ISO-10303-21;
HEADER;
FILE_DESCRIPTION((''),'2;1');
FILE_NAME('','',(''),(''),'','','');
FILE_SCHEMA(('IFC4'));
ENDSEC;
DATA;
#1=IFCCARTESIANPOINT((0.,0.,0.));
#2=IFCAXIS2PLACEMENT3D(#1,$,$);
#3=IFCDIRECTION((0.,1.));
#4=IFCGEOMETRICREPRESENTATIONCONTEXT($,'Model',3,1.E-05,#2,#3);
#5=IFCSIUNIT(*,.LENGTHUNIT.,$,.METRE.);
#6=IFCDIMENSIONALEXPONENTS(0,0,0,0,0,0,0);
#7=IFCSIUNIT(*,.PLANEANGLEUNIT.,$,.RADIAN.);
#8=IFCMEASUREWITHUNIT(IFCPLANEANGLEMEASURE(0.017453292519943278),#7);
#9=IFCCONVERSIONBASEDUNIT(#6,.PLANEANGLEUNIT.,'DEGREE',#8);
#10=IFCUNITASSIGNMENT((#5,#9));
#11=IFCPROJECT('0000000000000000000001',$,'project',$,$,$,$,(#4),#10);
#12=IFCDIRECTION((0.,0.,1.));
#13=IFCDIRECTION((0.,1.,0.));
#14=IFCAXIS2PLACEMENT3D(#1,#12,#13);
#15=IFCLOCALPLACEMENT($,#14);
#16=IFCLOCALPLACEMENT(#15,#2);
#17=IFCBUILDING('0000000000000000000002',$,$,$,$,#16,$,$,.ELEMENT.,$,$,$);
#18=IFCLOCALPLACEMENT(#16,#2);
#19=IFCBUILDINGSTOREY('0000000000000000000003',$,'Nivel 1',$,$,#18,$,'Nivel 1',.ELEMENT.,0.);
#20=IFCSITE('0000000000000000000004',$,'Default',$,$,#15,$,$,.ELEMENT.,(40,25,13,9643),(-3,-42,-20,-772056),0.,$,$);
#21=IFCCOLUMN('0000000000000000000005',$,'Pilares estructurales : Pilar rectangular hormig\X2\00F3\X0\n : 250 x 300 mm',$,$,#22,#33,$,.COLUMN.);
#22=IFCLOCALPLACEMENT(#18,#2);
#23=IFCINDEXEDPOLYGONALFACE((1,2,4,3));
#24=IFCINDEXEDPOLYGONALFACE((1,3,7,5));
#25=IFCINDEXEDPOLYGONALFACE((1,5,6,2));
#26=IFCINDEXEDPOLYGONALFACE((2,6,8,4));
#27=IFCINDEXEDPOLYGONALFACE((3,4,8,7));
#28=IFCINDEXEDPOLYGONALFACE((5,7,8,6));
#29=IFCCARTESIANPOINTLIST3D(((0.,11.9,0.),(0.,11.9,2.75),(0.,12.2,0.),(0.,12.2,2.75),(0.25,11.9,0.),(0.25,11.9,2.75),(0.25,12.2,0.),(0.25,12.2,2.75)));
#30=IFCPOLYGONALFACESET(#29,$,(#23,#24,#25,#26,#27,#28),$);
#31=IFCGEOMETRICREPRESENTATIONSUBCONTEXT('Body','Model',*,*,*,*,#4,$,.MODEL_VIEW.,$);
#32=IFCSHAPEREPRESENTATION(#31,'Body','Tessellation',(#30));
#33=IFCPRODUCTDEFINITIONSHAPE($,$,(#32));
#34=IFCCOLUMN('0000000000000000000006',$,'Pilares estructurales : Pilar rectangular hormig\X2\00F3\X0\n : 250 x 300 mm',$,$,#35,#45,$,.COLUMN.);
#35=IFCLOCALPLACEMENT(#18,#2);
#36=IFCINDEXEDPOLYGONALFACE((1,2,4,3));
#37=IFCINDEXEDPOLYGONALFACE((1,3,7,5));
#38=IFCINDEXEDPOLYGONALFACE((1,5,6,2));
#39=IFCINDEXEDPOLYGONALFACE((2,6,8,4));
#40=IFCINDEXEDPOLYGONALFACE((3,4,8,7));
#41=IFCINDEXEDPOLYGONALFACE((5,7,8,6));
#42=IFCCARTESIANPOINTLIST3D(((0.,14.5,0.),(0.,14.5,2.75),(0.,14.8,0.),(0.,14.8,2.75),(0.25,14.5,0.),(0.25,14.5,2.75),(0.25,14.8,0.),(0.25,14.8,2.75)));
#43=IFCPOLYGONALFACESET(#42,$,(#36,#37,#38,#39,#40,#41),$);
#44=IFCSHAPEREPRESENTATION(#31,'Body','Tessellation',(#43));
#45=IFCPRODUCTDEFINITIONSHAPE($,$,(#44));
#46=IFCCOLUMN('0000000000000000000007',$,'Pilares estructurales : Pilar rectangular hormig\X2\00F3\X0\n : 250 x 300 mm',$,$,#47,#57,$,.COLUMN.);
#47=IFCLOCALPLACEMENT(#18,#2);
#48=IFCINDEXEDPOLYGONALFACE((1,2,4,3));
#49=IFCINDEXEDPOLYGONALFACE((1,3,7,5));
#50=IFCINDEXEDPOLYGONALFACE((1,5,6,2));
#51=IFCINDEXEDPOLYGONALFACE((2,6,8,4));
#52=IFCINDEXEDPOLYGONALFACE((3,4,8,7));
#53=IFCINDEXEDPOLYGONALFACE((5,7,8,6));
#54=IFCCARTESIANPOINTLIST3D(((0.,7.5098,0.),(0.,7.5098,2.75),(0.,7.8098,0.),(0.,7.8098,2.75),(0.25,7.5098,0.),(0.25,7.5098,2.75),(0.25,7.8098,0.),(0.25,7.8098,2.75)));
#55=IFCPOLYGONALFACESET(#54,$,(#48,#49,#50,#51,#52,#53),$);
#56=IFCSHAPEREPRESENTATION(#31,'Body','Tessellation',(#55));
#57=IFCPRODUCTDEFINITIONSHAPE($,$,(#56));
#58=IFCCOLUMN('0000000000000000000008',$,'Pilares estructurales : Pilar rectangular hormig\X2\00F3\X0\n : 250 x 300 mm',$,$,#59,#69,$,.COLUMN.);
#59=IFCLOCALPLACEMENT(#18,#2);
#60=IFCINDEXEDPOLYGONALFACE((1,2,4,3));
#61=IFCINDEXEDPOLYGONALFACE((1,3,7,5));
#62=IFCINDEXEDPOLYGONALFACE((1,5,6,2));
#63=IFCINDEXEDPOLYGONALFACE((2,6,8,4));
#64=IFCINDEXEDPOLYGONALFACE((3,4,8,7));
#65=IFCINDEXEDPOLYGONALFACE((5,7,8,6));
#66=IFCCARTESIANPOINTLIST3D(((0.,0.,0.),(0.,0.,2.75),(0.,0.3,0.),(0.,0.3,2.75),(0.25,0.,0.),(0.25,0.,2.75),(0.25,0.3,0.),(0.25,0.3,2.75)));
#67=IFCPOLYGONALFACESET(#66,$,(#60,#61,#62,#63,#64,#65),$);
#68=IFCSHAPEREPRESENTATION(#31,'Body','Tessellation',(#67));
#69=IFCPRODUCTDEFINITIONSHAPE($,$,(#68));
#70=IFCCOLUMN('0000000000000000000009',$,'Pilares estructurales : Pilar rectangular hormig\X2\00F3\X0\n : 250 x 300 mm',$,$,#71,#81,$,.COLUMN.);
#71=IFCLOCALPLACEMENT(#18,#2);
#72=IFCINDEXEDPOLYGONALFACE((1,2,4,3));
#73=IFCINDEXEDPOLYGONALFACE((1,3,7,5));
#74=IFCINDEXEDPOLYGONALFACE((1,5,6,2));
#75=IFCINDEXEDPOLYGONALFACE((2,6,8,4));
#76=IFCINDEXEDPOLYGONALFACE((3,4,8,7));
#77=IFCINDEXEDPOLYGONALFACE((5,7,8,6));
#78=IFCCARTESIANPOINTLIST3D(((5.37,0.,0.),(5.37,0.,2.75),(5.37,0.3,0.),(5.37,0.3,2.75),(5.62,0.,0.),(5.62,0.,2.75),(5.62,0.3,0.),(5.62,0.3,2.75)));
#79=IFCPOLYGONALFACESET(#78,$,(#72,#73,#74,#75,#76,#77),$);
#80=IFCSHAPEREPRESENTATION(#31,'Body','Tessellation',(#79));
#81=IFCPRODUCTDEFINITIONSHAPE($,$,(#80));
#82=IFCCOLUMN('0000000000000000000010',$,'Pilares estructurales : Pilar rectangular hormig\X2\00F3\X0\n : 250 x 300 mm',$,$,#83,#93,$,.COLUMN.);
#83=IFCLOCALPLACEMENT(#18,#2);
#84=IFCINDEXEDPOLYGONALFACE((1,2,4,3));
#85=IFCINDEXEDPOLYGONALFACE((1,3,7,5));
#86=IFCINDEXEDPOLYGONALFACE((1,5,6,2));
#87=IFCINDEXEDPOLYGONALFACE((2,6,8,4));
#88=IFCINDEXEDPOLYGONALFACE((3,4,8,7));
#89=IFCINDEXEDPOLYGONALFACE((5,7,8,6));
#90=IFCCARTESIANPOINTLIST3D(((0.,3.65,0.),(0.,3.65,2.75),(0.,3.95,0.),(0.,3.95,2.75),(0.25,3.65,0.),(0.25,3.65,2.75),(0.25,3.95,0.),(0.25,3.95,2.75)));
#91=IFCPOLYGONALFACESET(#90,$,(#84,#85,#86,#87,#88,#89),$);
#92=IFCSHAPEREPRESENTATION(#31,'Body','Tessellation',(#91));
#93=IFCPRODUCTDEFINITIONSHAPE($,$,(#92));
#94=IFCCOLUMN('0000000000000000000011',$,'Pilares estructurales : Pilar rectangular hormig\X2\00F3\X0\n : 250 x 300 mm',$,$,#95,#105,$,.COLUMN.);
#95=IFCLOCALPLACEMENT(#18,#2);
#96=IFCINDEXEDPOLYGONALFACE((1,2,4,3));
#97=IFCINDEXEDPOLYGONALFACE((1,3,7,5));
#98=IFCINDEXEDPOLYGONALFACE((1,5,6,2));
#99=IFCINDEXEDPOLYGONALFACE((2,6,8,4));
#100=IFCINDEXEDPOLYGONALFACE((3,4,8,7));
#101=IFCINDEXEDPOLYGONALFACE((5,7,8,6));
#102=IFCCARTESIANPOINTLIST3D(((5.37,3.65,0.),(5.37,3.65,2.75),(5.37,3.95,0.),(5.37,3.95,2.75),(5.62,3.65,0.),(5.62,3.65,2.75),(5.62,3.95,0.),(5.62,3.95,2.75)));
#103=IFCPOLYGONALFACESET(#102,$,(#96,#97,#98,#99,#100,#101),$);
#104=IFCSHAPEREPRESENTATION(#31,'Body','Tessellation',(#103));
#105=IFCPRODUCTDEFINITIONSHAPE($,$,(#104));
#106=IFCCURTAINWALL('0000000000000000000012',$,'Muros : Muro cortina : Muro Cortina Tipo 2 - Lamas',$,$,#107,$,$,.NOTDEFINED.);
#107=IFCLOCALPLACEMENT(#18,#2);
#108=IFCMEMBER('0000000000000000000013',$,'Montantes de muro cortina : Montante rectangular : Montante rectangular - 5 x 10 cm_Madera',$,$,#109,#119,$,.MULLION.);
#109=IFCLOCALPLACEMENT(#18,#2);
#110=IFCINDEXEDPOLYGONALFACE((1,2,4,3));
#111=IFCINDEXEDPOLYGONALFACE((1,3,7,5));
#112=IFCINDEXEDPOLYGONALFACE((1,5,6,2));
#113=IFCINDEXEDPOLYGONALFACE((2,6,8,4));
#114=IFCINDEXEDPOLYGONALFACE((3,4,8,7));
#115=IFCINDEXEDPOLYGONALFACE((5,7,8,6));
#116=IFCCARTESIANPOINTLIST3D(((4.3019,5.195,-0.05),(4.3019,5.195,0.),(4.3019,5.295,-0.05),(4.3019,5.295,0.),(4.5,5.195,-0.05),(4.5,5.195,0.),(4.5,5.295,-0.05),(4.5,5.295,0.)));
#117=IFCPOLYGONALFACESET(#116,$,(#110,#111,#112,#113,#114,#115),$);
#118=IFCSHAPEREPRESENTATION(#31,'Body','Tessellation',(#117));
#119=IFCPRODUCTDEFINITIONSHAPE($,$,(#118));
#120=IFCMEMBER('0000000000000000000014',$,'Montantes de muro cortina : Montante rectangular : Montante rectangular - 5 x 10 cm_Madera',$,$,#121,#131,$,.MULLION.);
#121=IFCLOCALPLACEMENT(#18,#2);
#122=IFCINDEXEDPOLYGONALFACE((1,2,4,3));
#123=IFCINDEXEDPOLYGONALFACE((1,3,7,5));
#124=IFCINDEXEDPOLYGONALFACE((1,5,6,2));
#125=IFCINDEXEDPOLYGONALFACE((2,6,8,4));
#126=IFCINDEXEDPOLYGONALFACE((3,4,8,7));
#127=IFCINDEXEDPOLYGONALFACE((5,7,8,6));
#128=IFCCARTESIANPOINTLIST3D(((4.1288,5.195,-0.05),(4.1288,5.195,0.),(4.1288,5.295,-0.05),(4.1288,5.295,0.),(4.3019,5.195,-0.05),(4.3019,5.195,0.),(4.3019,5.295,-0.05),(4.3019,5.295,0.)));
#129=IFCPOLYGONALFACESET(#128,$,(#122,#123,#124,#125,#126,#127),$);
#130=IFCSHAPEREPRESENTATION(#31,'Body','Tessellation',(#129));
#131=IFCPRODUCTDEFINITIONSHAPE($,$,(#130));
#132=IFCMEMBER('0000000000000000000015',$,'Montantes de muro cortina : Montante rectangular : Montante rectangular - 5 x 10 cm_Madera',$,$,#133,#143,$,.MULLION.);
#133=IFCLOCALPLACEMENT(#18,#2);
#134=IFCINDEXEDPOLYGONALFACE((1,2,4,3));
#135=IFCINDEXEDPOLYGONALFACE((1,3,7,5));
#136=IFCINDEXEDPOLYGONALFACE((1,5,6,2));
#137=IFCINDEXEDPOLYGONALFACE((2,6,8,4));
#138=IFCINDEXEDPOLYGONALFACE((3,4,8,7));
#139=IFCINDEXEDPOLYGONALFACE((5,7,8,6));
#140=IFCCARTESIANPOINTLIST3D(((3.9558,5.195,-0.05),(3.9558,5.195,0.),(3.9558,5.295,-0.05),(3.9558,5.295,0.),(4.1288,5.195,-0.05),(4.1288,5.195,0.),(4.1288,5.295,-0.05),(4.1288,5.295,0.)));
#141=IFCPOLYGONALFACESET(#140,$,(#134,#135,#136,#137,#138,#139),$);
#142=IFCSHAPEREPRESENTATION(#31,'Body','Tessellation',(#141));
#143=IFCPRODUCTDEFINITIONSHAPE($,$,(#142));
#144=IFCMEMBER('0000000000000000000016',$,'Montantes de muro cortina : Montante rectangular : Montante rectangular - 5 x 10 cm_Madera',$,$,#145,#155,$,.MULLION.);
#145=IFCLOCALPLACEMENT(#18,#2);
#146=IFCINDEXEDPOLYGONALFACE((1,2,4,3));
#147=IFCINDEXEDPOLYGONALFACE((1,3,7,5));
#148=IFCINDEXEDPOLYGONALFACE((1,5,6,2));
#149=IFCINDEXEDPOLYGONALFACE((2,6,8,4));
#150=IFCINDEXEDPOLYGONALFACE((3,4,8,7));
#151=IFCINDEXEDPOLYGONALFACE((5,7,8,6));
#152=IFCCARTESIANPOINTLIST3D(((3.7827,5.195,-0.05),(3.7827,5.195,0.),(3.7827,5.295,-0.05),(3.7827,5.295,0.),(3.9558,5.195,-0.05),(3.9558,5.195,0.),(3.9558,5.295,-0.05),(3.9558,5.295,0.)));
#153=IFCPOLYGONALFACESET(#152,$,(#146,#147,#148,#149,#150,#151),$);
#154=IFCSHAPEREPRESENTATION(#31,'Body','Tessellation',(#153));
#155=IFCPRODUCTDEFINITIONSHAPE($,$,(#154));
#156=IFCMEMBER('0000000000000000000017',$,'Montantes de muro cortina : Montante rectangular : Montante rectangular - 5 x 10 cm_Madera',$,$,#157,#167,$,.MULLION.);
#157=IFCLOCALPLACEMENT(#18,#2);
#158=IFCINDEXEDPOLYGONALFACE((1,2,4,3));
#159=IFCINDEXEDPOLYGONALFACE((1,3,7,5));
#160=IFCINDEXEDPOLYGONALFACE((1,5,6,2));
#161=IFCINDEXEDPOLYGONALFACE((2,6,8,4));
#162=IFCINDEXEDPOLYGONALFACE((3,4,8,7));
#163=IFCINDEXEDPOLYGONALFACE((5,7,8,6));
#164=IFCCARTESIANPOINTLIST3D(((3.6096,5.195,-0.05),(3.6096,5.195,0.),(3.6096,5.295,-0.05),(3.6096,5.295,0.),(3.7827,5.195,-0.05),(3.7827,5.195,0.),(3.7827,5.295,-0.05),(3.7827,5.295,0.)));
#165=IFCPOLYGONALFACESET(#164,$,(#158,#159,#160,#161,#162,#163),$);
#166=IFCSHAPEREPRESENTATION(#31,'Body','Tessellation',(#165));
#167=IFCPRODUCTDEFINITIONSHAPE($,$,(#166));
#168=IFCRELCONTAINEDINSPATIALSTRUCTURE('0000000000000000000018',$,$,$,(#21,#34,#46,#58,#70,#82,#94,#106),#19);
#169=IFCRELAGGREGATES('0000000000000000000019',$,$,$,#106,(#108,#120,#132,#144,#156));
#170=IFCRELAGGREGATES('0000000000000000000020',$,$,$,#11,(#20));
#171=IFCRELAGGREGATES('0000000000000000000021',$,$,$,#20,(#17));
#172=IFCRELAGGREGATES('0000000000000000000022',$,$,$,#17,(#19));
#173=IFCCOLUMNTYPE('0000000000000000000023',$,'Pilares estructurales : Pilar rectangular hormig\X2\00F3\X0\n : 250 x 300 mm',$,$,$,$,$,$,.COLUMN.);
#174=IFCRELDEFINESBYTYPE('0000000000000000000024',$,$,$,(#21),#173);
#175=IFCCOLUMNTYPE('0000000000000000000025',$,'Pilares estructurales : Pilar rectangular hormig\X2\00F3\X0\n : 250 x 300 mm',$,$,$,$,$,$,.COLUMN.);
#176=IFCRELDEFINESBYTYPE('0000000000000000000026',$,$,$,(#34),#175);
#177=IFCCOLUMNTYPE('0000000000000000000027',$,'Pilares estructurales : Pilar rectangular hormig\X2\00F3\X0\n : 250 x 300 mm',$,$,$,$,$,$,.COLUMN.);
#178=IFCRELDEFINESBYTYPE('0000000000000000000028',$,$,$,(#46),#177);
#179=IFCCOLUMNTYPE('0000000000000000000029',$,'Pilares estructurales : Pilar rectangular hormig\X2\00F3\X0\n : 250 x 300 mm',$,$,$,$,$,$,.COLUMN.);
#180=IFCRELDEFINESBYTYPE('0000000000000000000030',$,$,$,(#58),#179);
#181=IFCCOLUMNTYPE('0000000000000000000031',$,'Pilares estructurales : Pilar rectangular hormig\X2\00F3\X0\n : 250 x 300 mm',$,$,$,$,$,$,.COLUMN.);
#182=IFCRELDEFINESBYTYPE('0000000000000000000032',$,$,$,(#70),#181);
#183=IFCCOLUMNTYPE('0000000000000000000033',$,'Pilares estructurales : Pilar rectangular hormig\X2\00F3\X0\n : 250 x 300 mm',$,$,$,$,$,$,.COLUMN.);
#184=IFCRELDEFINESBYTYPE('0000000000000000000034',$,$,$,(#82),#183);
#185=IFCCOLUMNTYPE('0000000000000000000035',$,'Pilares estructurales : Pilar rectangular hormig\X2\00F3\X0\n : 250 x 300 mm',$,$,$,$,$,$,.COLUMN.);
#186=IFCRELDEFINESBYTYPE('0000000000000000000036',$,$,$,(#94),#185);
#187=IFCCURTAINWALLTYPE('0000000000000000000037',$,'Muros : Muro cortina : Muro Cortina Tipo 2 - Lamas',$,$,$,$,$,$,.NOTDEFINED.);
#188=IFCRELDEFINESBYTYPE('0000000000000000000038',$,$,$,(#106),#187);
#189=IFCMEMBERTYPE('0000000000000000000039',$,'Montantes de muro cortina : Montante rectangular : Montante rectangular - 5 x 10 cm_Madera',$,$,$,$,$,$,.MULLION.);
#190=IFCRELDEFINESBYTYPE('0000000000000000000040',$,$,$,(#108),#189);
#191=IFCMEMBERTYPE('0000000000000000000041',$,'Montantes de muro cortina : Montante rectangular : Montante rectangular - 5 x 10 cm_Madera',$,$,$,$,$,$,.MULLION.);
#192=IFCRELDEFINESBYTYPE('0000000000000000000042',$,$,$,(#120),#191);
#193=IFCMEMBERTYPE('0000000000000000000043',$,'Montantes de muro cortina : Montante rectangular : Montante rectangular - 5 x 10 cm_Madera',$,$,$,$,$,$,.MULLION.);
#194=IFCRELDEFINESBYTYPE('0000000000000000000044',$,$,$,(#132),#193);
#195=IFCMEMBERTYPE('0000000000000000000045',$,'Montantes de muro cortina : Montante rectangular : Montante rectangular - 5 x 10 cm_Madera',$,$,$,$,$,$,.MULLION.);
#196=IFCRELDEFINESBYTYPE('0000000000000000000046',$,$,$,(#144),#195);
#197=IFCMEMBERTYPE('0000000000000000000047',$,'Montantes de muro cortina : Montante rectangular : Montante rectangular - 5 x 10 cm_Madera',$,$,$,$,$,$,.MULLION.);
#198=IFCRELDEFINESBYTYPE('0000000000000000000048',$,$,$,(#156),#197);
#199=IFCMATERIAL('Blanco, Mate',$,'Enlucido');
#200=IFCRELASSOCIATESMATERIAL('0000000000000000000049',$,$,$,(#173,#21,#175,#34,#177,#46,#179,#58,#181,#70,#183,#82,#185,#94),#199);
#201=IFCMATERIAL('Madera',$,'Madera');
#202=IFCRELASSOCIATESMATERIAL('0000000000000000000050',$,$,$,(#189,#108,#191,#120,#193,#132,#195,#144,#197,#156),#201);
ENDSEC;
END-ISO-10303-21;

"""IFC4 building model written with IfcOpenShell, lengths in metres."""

from ifc_helpers import new_model, entity, si_unit, converted_unit, direction, frame, origin, place, context, subcontext, project, spatial, indexed_curve, outline, extrude, source, transform, mapped, material, type_object, type_shapes, element, aggregate, save


model = new_model("IFC4")

# Units and contexts
model_context = context("Model", 3, precision=1e-05, world=origin(), true_north=direction((0.0, 1.0)))
body_context = subcontext(model_context, "Body", "Model", "MODEL_VIEW")
ifc_project = project(units=[si_unit("LENGTHUNIT", "METRE"), converted_unit("PLANEANGLEUNIT", "DEGREE", entity("IfcPlaneAngleMeasure", 0.017453292519943278), si_unit("PLANEANGLEUNIT", "RADIAN"), dimensions=[0, 0, 0, 0, 0, 0, 0])], contexts=[model_context])

# Site, building, storey
site_placement = place(None, frame((0.0, 0.0, 0.0), z_axis=(0.0, 0.0, 1.0), x_axis=(0.0, 1.0, 0.0)))
site = spatial("IfcSite", under=ifc_project, at=site_placement, Name="Default", CompositionType="ELEMENT", RefLatitude=(40, 25, 13, 9643), RefLongitude=(-3, -42, -20, -772056), RefElevation=0.0)
building_placement = place(site_placement, origin())
building = spatial("IfcBuilding", under=site, at=building_placement, CompositionType="ELEMENT")
storey_placement = place(building_placement, origin())
storey = spatial("IfcBuildingStorey", under=building, at=storey_placement, Name="Nivel 1", LongName="Nivel 1", CompositionType="ELEMENT", Elevation=0.0)

# Columns
ifc_material_1 = material(Name="Blanco, Mate", Category="Enlucido")
column_type_1 = type_object("IfcColumnType", Name="Pilares estructurales : Pilar rectangular hormigón : 250 x 300 mm", PredefinedType="COLUMN", material=ifc_material_1)
shared_shape_1 = source(origin(), body_context, "Body", "SweptSolid", [
    extrude(outline(indexed_curve([(-1.375, -0.15), (1.375, -0.15), (1.375, 0.15), (-1.375, 0.15), (-1.375, -0.15)], self_intersect=False)), frame((0.0, 12.05, 1.375), z_axis=(1.0, 0.0, 0.0), x_axis=(0.0, 0.0, 1.0)), (0.0, 0.0, 1.0), 0.25),
])
type_shapes(column_type_1, [shared_shape_1])
column_1_placement = place(storey_placement, origin())
element("IfcColumn", 1, at=column_1_placement, inside=storey, type_object=column_type_1, material=ifc_material_1, Name="Pilares estructurales : Pilar rectangular hormigón : 250 x 300 mm", PredefinedType="COLUMN", context=body_context, shape_type="MappedRepresentation", body=[
    mapped(shared_shape_1, transform((0.0, 0.0, 0.0), scale=1.0)),
])
column_type_2 = type_object("IfcColumnType", Name="Pilares estructurales : Pilar rectangular hormigón : 250 x 300 mm", PredefinedType="COLUMN", material=ifc_material_1)
shared_shape_2 = source(origin(), body_context, "Body", "SweptSolid", [
    extrude(outline(indexed_curve([(-1.375, -0.15), (1.375, -0.15), (1.375, 0.15), (-1.375, 0.15), (-1.375, -0.15)], self_intersect=False)), frame((0.0, 14.65, 1.375), z_axis=(1.0, 0.0, 0.0), x_axis=(0.0, 0.0, 1.0)), (0.0, 0.0, 1.0), 0.25),
])
type_shapes(column_type_2, [shared_shape_2])
column_2_placement = place(storey_placement, origin())
element("IfcColumn", 2, at=column_2_placement, inside=storey, type_object=column_type_2, material=ifc_material_1, Name="Pilares estructurales : Pilar rectangular hormigón : 250 x 300 mm", PredefinedType="COLUMN", context=body_context, shape_type="MappedRepresentation", body=[
    mapped(shared_shape_2, transform((0.0, 0.0, 0.0), scale=1.0)),
])
column_type_3 = type_object("IfcColumnType", Name="Pilares estructurales : Pilar rectangular hormigón : 250 x 300 mm", PredefinedType="COLUMN", material=ifc_material_1)
shared_shape_3 = source(origin(), body_context, "Body", "SweptSolid", [
    extrude(outline(indexed_curve([(-1.375, -0.15), (1.375, -0.15), (1.375, 0.15), (-1.375, 0.15), (-1.375, -0.15)], self_intersect=False)), frame((0.0, 7.6598, 1.375), z_axis=(1.0, 0.0, 0.0), x_axis=(0.0, 0.0, 1.0)), (0.0, 0.0, 1.0), 0.25),
])
type_shapes(column_type_3, [shared_shape_3])
column_3_placement = place(storey_placement, origin())
element("IfcColumn", 3, at=column_3_placement, inside=storey, type_object=column_type_3, material=ifc_material_1, Name="Pilares estructurales : Pilar rectangular hormigón : 250 x 300 mm", PredefinedType="COLUMN", context=body_context, shape_type="MappedRepresentation", body=[
    mapped(shared_shape_3, transform((0.0, 0.0, 0.0), scale=1.0)),
])
column_type_4 = type_object("IfcColumnType", Name="Pilares estructurales : Pilar rectangular hormigón : 250 x 300 mm", PredefinedType="COLUMN", material=ifc_material_1)
shared_shape_4 = source(origin(), body_context, "Body", "SweptSolid", [
    extrude(outline(indexed_curve([(-1.375, -0.15), (1.375, -0.15), (1.375, 0.15), (-1.375, 0.15), (-1.375, -0.15)], self_intersect=False)), frame((0.0, 0.15, 1.375), z_axis=(1.0, 0.0, 0.0), x_axis=(0.0, 0.0, 1.0)), (0.0, 0.0, 1.0), 0.25),
])
type_shapes(column_type_4, [shared_shape_4])
column_4_placement = place(storey_placement, origin())
element("IfcColumn", 4, at=column_4_placement, inside=storey, type_object=column_type_4, material=ifc_material_1, Name="Pilares estructurales : Pilar rectangular hormigón : 250 x 300 mm", PredefinedType="COLUMN", context=body_context, shape_type="MappedRepresentation", body=[
    mapped(shared_shape_4, transform((0.0, 0.0, 0.0), scale=1.0)),
])
column_type_5 = type_object("IfcColumnType", Name="Pilares estructurales : Pilar rectangular hormigón : 250 x 300 mm", PredefinedType="COLUMN", material=ifc_material_1)
shared_shape_5 = source(origin(), body_context, "Body", "SweptSolid", [
    extrude(outline(indexed_curve([(-1.375, -0.15), (1.375, -0.15), (1.375, 0.15), (-1.375, 0.15), (-1.375, -0.15)], self_intersect=False)), frame((5.37, 0.15, 1.375), z_axis=(1.0, 0.0, 0.0), x_axis=(0.0, 0.0, 1.0)), (0.0, 0.0, 1.0), 0.25),
])
type_shapes(column_type_5, [shared_shape_5])
column_5_placement = place(storey_placement, origin())
element("IfcColumn", 5, at=column_5_placement, inside=storey, type_object=column_type_5, material=ifc_material_1, Name="Pilares estructurales : Pilar rectangular hormigón : 250 x 300 mm", PredefinedType="COLUMN", context=body_context, shape_type="MappedRepresentation", body=[
    mapped(shared_shape_5, transform((0.0, 0.0, 0.0), scale=1.0)),
])
column_type_6 = type_object("IfcColumnType", Name="Pilares estructurales : Pilar rectangular hormigón : 250 x 300 mm", PredefinedType="COLUMN", material=ifc_material_1)
shared_shape_6 = source(origin(), body_context, "Body", "SweptSolid", [
    extrude(outline(indexed_curve([(-1.375, -0.15), (1.375, -0.15), (1.375, 0.15), (-1.375, 0.15), (-1.375, -0.15)], self_intersect=False)), frame((0.0, 3.8, 1.375), z_axis=(1.0, 0.0, 0.0), x_axis=(0.0, 0.0, 1.0)), (0.0, 0.0, 1.0), 0.25),
])
type_shapes(column_type_6, [shared_shape_6])
column_6_placement = place(storey_placement, origin())
element("IfcColumn", 6, at=column_6_placement, inside=storey, type_object=column_type_6, material=ifc_material_1, Name="Pilares estructurales : Pilar rectangular hormigón : 250 x 300 mm", PredefinedType="COLUMN", context=body_context, shape_type="MappedRepresentation", body=[
    mapped(shared_shape_6, transform((0.0, 0.0, 0.0), scale=1.0)),
])
column_type_7 = type_object("IfcColumnType", Name="Pilares estructurales : Pilar rectangular hormigón : 250 x 300 mm", PredefinedType="COLUMN", material=ifc_material_1)
shared_shape_7 = source(origin(), body_context, "Body", "SweptSolid", [
    extrude(outline(indexed_curve([(-1.375, -0.15), (1.375, -0.15), (1.375, 0.15), (-1.375, 0.15), (-1.375, -0.15)], self_intersect=False)), frame((5.37, 3.8, 1.375), z_axis=(1.0, 0.0, 0.0), x_axis=(0.0, 0.0, 1.0)), (0.0, 0.0, 1.0), 0.25),
])
type_shapes(column_type_7, [shared_shape_7])
column_7_placement = place(storey_placement, origin())
element("IfcColumn", 7, at=column_7_placement, inside=storey, type_object=column_type_7, material=ifc_material_1, Name="Pilares estructurales : Pilar rectangular hormigón : 250 x 300 mm", PredefinedType="COLUMN", context=body_context, shape_type="MappedRepresentation", body=[
    mapped(shared_shape_7, transform((0.0, 0.0, 0.0), scale=1.0)),
])

# Curtain wall, members
curtain_wall_type_1 = type_object("IfcCurtainWallType", Name="Muros : Muro cortina : Muro Cortina Tipo 2 - Lamas", PredefinedType="NOTDEFINED")
curtain_wall_1_placement = place(storey_placement, origin())
curtain_wall_1 = element("IfcCurtainWall", 8, at=curtain_wall_1_placement, inside=storey, type_object=curtain_wall_type_1, Name="Muros : Muro cortina : Muro Cortina Tipo 2 - Lamas", PredefinedType="NOTDEFINED")
ifc_material_2 = material(Name="Madera", Category="Madera")
member_type_1 = type_object("IfcMemberType", Name="Montantes de muro cortina : Montante rectangular : Montante rectangular - 5 x 10 cm_Madera", PredefinedType="MULLION", material=ifc_material_2)
shared_shape_8 = source(origin(), body_context, "Body", "SweptSolid", [
    extrude(outline(indexed_curve([(-0.099, -0.05), (0.099, -0.05), (0.099, 0.05), (-0.099, 0.05), (-0.099, -0.05)], self_intersect=False)), frame((4.401, 5.245, -0.05)), (0.0, 0.0, 1.0), 0.05),
])
type_shapes(member_type_1, [shared_shape_8])
member_1_placement = place(curtain_wall_1_placement, origin())
member_1 = element("IfcMember", 9, at=member_1_placement, type_object=member_type_1, material=ifc_material_2, Name="Montantes de muro cortina : Montante rectangular : Montante rectangular - 5 x 10 cm_Madera", PredefinedType="MULLION", context=body_context, shape_type="MappedRepresentation", body=[
    mapped(shared_shape_8, transform((0.0, 0.0, 0.0), scale=1.0)),
])
member_type_2 = type_object("IfcMemberType", Name="Montantes de muro cortina : Montante rectangular : Montante rectangular - 5 x 10 cm_Madera", PredefinedType="MULLION", material=ifc_material_2)
shared_shape_9 = source(origin(), body_context, "Body", "SweptSolid", [
    extrude(outline(indexed_curve([(-0.0865, -0.05), (0.0865, -0.05), (0.0865, 0.05), (-0.0865, 0.05), (-0.0865, -0.05)], self_intersect=False)), frame((4.2154, 5.245, -0.05)), (0.0, 0.0, 1.0), 0.05),
])
type_shapes(member_type_2, [shared_shape_9])
member_2_placement = place(curtain_wall_1_placement, origin())
member_2 = element("IfcMember", 10, at=member_2_placement, type_object=member_type_2, material=ifc_material_2, Name="Montantes de muro cortina : Montante rectangular : Montante rectangular - 5 x 10 cm_Madera", PredefinedType="MULLION", context=body_context, shape_type="MappedRepresentation", body=[
    mapped(shared_shape_9, transform((0.0, 0.0, 0.0), scale=1.0)),
])
member_type_3 = type_object("IfcMemberType", Name="Montantes de muro cortina : Montante rectangular : Montante rectangular - 5 x 10 cm_Madera", PredefinedType="MULLION", material=ifc_material_2)
shared_shape_10 = source(origin(), body_context, "Body", "SweptSolid", [
    extrude(outline(indexed_curve([(-0.0865, -0.05), (0.0865, -0.05), (0.0865, 0.05), (-0.0865, 0.05), (-0.0865, -0.05)], self_intersect=False)), frame((4.0423, 5.245, -0.05)), (0.0, 0.0, 1.0), 0.05),
])
type_shapes(member_type_3, [shared_shape_10])
member_3_placement = place(curtain_wall_1_placement, origin())
member_3 = element("IfcMember", 11, at=member_3_placement, type_object=member_type_3, material=ifc_material_2, Name="Montantes de muro cortina : Montante rectangular : Montante rectangular - 5 x 10 cm_Madera", PredefinedType="MULLION", context=body_context, shape_type="MappedRepresentation", body=[
    mapped(shared_shape_10, transform((0.0, 0.0, 0.0), scale=1.0)),
])
member_type_4 = type_object("IfcMemberType", Name="Montantes de muro cortina : Montante rectangular : Montante rectangular - 5 x 10 cm_Madera", PredefinedType="MULLION", material=ifc_material_2)
shared_shape_11 = source(origin(), body_context, "Body", "SweptSolid", [
    extrude(outline(indexed_curve([(-0.0865, -0.05), (0.0865, -0.05), (0.0865, 0.05), (-0.0865, 0.05), (-0.0865, -0.05)], self_intersect=False)), frame((3.8692, 5.245, -0.05)), (0.0, 0.0, 1.0), 0.05),
])
type_shapes(member_type_4, [shared_shape_11])
member_4_placement = place(curtain_wall_1_placement, origin())
member_4 = element("IfcMember", 12, at=member_4_placement, type_object=member_type_4, material=ifc_material_2, Name="Montantes de muro cortina : Montante rectangular : Montante rectangular - 5 x 10 cm_Madera", PredefinedType="MULLION", context=body_context, shape_type="MappedRepresentation", body=[
    mapped(shared_shape_11, transform((0.0, 0.0, 0.0), scale=1.0)),
])
member_type_5 = type_object("IfcMemberType", Name="Montantes de muro cortina : Montante rectangular : Montante rectangular - 5 x 10 cm_Madera", PredefinedType="MULLION", material=ifc_material_2)
shared_shape_12 = source(origin(), body_context, "Body", "SweptSolid", [
    extrude(outline(indexed_curve([(-0.0865, -0.05), (0.0865, -0.05), (0.0865, 0.05), (-0.0865, 0.05), (-0.0865, -0.05)], self_intersect=False)), frame((3.6962, 5.245, -0.05)), (0.0, 0.0, 1.0), 0.05),
])
type_shapes(member_type_5, [shared_shape_12])
member_5_placement = place(curtain_wall_1_placement, origin())
member_5 = element("IfcMember", 13, at=member_5_placement, type_object=member_type_5, material=ifc_material_2, Name="Montantes de muro cortina : Montante rectangular : Montante rectangular - 5 x 10 cm_Madera", PredefinedType="MULLION", context=body_context, shape_type="MappedRepresentation", body=[
    mapped(shared_shape_12, transform((0.0, 0.0, 0.0), scale=1.0)),
])
aggregate(curtain_wall_1, [member_1, member_2, member_3, member_4, member_5])

save(model, "model.ifc")
